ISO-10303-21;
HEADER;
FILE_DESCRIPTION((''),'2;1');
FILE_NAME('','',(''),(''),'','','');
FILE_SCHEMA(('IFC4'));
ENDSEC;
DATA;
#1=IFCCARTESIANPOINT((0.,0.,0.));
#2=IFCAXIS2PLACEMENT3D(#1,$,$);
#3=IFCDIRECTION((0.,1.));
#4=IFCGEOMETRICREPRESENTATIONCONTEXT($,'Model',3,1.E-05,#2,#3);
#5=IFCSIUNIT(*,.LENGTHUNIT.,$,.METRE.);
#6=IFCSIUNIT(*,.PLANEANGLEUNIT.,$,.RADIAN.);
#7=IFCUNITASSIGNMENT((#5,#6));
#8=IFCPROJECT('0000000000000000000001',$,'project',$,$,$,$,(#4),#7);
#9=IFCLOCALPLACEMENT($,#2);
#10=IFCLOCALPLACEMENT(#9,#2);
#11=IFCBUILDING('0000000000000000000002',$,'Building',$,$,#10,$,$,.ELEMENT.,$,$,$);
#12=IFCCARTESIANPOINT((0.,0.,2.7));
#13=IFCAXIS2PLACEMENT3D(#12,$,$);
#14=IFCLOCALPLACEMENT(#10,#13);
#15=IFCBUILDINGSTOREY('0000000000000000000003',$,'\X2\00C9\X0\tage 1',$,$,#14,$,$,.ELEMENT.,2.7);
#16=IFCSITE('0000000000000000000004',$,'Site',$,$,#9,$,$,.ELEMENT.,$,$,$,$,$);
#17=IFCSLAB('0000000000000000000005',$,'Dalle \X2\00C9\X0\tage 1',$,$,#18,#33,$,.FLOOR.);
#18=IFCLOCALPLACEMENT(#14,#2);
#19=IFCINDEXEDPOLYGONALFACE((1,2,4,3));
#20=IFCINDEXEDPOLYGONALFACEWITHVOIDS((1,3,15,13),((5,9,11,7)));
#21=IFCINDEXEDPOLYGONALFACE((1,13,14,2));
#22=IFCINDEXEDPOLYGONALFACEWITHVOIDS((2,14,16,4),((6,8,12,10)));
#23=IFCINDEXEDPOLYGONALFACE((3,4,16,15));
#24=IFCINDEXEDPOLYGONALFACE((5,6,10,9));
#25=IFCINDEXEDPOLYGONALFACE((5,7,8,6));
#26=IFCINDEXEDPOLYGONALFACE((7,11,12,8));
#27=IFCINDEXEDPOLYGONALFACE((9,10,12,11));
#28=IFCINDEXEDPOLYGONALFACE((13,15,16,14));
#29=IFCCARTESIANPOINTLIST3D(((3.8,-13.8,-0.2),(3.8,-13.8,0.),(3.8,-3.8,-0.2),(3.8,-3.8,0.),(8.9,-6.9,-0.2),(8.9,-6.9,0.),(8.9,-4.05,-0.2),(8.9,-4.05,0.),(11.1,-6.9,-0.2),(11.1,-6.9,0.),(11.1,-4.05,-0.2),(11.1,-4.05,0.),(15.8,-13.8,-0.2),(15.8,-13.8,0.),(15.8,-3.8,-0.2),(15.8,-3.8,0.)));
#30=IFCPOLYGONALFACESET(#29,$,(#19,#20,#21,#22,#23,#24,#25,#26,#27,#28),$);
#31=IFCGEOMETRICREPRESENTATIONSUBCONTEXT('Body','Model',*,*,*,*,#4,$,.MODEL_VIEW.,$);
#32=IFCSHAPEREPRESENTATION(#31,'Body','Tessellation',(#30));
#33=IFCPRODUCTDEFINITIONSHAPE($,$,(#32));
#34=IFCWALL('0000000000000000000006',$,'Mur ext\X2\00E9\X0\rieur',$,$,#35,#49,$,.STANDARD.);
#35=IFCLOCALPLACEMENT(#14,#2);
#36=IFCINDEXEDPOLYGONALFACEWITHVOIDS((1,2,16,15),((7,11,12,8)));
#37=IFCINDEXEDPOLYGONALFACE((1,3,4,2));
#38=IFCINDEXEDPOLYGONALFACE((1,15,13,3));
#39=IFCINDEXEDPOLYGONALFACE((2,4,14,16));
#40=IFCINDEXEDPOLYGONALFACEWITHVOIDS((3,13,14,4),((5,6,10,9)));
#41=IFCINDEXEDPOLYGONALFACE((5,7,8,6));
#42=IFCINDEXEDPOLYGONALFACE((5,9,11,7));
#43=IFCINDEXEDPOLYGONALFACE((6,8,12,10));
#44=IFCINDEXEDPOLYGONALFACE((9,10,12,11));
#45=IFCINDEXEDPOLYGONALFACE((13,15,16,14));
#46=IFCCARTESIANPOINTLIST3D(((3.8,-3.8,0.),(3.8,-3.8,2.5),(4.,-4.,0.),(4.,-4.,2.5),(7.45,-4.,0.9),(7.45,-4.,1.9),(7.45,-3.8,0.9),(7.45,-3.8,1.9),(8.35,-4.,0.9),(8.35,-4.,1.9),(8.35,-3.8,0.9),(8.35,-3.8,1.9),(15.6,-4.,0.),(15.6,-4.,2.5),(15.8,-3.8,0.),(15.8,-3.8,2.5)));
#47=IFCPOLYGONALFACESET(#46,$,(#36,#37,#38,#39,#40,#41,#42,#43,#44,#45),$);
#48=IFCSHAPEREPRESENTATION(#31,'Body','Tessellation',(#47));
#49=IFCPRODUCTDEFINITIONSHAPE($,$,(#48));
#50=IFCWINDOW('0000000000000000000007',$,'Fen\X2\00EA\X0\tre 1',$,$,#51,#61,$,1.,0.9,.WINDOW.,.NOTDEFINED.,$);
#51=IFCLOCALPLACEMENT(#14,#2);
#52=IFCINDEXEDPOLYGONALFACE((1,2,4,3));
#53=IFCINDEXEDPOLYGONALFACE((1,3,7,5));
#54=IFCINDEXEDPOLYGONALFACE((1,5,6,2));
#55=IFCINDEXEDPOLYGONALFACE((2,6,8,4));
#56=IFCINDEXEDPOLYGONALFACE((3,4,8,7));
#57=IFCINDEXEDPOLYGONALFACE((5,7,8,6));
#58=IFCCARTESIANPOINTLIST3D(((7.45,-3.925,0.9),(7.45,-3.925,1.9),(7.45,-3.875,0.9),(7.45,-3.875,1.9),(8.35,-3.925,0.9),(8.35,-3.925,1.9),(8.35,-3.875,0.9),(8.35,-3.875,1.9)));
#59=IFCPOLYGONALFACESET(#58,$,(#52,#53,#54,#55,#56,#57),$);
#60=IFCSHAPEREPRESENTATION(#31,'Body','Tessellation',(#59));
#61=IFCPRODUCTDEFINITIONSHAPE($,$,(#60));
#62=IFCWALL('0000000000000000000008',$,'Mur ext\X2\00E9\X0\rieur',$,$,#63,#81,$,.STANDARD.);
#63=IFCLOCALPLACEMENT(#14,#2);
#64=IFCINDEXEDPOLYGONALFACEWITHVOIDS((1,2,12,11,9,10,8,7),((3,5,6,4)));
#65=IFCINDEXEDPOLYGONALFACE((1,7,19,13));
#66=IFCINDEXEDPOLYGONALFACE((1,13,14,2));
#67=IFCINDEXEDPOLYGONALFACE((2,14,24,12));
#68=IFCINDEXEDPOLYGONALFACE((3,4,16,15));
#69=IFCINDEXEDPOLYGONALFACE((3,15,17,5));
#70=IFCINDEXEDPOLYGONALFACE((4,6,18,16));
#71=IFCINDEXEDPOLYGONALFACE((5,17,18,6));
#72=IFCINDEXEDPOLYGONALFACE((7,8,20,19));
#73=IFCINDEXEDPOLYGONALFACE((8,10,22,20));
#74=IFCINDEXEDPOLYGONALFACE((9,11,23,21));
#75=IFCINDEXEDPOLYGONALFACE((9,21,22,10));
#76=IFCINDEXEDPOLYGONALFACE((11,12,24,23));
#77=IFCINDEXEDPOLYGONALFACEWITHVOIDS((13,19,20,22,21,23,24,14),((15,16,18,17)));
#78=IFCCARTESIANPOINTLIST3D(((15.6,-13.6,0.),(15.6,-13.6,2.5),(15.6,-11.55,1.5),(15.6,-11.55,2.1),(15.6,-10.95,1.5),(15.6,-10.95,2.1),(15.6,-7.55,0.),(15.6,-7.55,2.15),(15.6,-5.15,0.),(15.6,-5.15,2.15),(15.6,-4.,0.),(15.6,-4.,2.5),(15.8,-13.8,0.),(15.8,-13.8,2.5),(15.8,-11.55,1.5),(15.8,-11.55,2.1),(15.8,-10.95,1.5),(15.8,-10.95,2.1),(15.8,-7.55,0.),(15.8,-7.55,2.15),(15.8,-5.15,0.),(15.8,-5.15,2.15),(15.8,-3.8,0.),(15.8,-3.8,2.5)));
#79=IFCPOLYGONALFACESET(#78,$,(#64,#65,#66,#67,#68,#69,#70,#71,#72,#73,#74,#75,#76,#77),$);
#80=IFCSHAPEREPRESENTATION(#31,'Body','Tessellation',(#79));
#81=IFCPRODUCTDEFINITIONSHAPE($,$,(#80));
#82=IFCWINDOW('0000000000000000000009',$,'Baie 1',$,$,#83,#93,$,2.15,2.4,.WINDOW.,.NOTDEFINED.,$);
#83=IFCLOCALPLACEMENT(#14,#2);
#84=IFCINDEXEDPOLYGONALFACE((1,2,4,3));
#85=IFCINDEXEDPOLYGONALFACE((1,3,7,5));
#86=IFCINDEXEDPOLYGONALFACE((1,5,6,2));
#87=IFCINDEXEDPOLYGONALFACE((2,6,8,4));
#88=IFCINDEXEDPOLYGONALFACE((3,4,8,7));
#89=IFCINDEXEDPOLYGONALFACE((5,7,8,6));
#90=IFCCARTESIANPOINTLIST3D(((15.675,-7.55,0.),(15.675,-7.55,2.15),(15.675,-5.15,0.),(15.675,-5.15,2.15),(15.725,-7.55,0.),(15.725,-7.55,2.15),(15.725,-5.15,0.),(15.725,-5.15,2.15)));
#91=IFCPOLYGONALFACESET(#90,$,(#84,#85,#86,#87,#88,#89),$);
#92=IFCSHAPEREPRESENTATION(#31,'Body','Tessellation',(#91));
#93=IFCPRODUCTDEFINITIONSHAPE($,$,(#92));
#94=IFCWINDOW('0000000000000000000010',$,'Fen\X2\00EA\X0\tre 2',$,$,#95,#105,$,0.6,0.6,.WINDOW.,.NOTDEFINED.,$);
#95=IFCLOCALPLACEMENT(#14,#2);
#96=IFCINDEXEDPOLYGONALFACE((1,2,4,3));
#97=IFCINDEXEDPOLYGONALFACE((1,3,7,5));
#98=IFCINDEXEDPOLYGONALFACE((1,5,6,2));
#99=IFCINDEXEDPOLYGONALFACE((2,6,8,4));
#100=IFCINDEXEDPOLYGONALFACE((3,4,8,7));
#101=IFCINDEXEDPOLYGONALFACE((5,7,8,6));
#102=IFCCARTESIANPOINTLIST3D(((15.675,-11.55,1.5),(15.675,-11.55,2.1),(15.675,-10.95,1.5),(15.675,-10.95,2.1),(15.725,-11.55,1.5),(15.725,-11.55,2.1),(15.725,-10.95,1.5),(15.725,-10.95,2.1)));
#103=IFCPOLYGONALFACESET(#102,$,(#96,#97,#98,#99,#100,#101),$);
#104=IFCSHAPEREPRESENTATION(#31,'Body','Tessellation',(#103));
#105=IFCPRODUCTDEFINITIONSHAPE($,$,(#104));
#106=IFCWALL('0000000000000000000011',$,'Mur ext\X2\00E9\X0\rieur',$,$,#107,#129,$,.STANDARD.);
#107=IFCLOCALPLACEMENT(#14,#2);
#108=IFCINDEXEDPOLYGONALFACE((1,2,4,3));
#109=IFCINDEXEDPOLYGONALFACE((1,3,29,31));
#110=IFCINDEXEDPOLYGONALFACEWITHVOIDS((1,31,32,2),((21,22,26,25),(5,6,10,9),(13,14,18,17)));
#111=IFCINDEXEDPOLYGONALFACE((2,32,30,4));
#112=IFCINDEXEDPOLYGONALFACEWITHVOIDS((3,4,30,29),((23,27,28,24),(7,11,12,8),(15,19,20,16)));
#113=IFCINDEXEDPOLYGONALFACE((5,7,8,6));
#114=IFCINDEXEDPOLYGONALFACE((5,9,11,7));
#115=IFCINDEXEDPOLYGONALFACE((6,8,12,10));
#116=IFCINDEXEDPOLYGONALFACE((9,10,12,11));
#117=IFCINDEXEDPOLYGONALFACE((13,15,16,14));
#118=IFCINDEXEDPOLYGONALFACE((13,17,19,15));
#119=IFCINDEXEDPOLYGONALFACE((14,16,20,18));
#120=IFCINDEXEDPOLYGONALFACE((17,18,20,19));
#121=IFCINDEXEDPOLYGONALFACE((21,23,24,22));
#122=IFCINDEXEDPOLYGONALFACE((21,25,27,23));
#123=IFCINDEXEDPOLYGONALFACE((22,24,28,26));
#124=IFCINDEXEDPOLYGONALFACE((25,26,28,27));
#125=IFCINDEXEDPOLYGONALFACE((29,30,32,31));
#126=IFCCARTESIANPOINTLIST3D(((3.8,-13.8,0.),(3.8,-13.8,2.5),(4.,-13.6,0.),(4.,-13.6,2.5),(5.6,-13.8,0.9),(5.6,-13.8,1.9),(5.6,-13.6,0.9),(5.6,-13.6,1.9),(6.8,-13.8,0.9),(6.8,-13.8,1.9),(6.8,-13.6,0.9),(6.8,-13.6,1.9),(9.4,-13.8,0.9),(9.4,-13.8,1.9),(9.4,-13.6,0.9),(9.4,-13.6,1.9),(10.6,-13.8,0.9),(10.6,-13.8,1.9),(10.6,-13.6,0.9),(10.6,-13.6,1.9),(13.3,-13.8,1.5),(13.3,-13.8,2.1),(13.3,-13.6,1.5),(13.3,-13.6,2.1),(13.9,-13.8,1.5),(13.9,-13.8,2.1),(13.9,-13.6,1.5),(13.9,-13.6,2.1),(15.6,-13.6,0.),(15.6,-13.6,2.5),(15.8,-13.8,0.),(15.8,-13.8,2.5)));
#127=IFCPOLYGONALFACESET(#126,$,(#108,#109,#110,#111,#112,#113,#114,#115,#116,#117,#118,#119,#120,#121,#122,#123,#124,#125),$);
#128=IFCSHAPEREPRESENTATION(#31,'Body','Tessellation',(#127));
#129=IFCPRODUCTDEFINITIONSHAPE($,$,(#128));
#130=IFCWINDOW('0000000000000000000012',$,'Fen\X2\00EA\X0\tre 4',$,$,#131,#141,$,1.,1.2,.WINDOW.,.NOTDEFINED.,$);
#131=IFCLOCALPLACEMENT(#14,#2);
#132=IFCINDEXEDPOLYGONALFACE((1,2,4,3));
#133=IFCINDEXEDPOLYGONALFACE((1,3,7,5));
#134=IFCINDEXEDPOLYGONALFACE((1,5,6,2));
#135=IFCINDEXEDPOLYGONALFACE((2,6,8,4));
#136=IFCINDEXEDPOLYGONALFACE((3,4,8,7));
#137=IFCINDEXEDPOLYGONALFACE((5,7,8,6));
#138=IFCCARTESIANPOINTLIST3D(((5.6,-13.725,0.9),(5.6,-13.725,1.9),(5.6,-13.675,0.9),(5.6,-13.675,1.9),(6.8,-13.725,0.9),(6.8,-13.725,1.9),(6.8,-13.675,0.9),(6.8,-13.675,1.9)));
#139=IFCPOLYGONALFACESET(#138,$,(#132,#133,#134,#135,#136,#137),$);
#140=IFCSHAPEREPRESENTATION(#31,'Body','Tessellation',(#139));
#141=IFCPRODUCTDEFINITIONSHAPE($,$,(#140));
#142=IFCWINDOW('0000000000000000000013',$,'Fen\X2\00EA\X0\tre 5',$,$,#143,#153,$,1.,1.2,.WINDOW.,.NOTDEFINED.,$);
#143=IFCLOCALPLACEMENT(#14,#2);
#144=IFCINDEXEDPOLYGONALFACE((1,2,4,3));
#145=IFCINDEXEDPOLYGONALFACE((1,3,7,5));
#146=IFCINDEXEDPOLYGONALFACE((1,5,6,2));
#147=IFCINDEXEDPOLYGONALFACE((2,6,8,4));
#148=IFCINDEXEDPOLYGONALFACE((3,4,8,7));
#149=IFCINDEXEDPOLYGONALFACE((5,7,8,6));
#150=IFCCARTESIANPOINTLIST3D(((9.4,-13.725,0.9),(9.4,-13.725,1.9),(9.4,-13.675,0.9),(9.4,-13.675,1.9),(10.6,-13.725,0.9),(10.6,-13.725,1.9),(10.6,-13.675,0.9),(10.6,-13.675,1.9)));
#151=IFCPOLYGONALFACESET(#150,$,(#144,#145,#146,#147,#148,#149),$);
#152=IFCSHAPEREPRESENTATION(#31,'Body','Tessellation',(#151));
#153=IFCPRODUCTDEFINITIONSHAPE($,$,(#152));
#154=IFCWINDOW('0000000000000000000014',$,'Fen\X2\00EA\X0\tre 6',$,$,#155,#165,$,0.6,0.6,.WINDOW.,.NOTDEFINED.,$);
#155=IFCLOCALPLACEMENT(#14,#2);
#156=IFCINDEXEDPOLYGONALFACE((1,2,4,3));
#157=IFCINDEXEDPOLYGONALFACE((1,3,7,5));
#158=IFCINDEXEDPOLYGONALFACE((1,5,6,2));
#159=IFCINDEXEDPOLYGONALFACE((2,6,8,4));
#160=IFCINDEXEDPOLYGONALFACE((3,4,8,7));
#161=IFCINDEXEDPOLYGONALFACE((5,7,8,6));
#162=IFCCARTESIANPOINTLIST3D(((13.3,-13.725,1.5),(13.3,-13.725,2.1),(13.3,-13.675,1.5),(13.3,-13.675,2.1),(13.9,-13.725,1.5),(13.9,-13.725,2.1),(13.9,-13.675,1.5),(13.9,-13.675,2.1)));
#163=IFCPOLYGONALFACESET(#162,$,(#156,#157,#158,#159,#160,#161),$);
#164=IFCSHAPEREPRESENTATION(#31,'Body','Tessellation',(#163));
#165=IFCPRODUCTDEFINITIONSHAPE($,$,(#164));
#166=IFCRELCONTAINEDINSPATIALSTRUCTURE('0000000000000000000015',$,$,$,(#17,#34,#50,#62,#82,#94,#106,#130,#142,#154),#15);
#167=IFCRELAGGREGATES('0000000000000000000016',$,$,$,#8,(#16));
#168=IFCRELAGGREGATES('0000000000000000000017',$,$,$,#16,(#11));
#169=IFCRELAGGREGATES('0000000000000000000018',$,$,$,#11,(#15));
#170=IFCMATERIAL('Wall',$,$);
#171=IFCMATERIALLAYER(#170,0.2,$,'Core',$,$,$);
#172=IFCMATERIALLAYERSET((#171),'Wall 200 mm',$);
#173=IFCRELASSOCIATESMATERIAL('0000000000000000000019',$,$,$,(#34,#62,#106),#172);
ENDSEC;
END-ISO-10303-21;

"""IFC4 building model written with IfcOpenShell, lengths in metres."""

from ifc_helpers import new_model, si_unit, direction, frame, origin, origin_2d, place, context, subcontext, project, spatial, polyline, rectangle, outline, extrude, material, layer, layer_set, layer_usage, element, fill, save


model = new_model("IFC4")

# Units and contexts
model_context = context("Model", 3, precision=1e-05, world=origin(), true_north=direction((0.0, 1.0)))
body_context = subcontext(model_context, "Body", "Model", "MODEL_VIEW")
ifc_project = project(units=[si_unit("LENGTHUNIT", "METRE"), si_unit("PLANEANGLEUNIT", "RADIAN")], contexts=[model_context])

# Site, building, storey
site_placement = place(None, origin())
site = spatial("IfcSite", under=ifc_project, at=site_placement, Name="Site", CompositionType="ELEMENT")
building_placement = place(site_placement, origin())
building = spatial("IfcBuilding", under=site, at=building_placement, Name="Building", CompositionType="ELEMENT")
storey_placement = place(building_placement, frame((0.0, 0.0, 2.7)))
storey = spatial("IfcBuildingStorey", under=building, at=storey_placement, Name="Étage 1", CompositionType="ELEMENT", Elevation=2.7)

# Slab
slab_placement = place(storey_placement, origin())
element("IfcSlab", 1, at=slab_placement, inside=storey, Name="Dalle Étage 1", PredefinedType="FLOOR", context=body_context, shape_type="SweptSolid", body=[
    extrude(outline(polyline([(3.8, -13.8), (15.8, -13.8), (15.8, -3.8), (3.8, -3.8), (3.8, -13.8)]), holes=[polyline([(11.1, -4.05), (11.1, -6.9), (8.9, -6.9), (8.9, -4.05), (11.1, -4.05)])]), frame((0.0, 0.0, -0.2)), (0.0, 0.0, 1.0), 0.2),
])

# Wall, opening, window
ifc_material = material(Name="Wall")
ifc_layer = layer(ifc_material, 0.2, Name="Core")
ifc_layer_set = layer_set([ifc_layer], Name="Wall 200 mm")
ifc_layer_usage = layer_usage(ifc_layer_set, "AXIS2", "POSITIVE", -0.1)
wall_1_placement = place(storey_placement, frame((3.9, -3.9, 0.0)))
wall_1 = element("IfcWall", 2, at=wall_1_placement, inside=storey, material=ifc_layer_usage, Name="Mur extérieur", PredefinedType="STANDARD", context=body_context, shape_type="SweptSolid", body=[
    extrude(outline(polyline([(0.0, 0.0), (0.1, -0.1), (11.7, -0.1), (11.8, 0.0), (11.9, 0.1), (-0.1, 0.1), (0.0, 0.0)])), origin(), (0.0, 0.0, 1.0), 2.5),
])
opening_1_placement = place(wall_1_placement, frame((4.0, 0.0, 0.9)))
opening_1 = element("IfcOpeningElement", 3, at=opening_1_placement, cuts=wall_1, PredefinedType="OPENING", context=body_context, shape_type="SweptSolid", body=[
    extrude(rectangle(XDim=0.9, YDim=0.4, at=origin_2d()), origin(), (0.0, 0.0, 1.0), 1.0),
])
window_1_placement = place(opening_1_placement, origin())
window_1 = element("IfcWindow", 4, at=window_1_placement, inside=storey, Name="Fenêtre 1", OverallHeight=1.0, OverallWidth=0.9, PartitioningType="NOTDEFINED", PredefinedType="WINDOW", context=body_context, shape_type="SweptSolid", body=[
    extrude(rectangle(XDim=0.9, YDim=0.05, at=origin_2d()), origin(), (0.0, 0.0, 1.0), 1.0),
])
fill(opening_1, window_1)

# Walls, openings, windows
wall_2_placement = place(storey_placement, frame((15.7, -3.9, 0.0), z_axis=(0.0, 0.0, 1.0), x_axis=(0.0, -1.0, 0.0)))
wall_2 = element("IfcWall", 5, at=wall_2_placement, inside=storey, material=ifc_layer_usage, Name="Mur extérieur", PredefinedType="STANDARD", context=body_context, shape_type="SweptSolid", body=[
    extrude(outline(polyline([(0.0, 0.0), (0.1, -0.1), (9.7, -0.1), (9.8, 0.0), (9.9, 0.1), (-0.1, 0.1), (0.0, 0.0)])), origin(), (0.0, 0.0, 1.0), 2.5),
])
opening_2_placement = place(wall_2_placement, frame((2.45, 0.0, 0.0)))
opening_2 = element("IfcOpeningElement", 6, at=opening_2_placement, cuts=wall_2, PredefinedType="OPENING", context=body_context, shape_type="SweptSolid", body=[
    extrude(rectangle(XDim=2.4, YDim=0.4, at=origin_2d()), origin(), (0.0, 0.0, 1.0), 2.15),
])
opening_3_placement = place(wall_2_placement, frame((7.35, 0.0, 1.5)))
opening_3 = element("IfcOpeningElement", 7, at=opening_3_placement, cuts=wall_2, PredefinedType="OPENING", context=body_context, shape_type="SweptSolid", body=[
    extrude(rectangle(XDim=0.6, YDim=0.4, at=origin_2d()), origin(), (0.0, 0.0, 1.0), 0.6),
])
window_2_placement = place(opening_2_placement, origin())
window_2 = element("IfcWindow", 8, at=window_2_placement, inside=storey, Name="Baie 1", OverallHeight=2.15, OverallWidth=2.4, PartitioningType="NOTDEFINED", PredefinedType="WINDOW", context=body_context, shape_type="SweptSolid", body=[
    extrude(rectangle(XDim=2.4, YDim=0.05, at=origin_2d()), origin(), (0.0, 0.0, 1.0), 2.15),
])
fill(opening_2, window_2)
window_3_placement = place(opening_3_placement, origin())
window_3 = element("IfcWindow", 9, at=window_3_placement, inside=storey, Name="Fenêtre 2", OverallHeight=0.6, OverallWidth=0.6, PartitioningType="NOTDEFINED", PredefinedType="WINDOW", context=body_context, shape_type="SweptSolid", body=[
    extrude(rectangle(XDim=0.6, YDim=0.05, at=origin_2d()), origin(), (0.0, 0.0, 1.0), 0.6),
])
fill(opening_3, window_3)
wall_3_placement = place(storey_placement, frame((15.7, -13.7, 0.0), z_axis=(0.0, 0.0, 1.0), x_axis=(-1.0, 0.0, 0.0)))
wall_3 = element("IfcWall", 10, at=wall_3_placement, inside=storey, material=ifc_layer_usage, Name="Mur extérieur", PredefinedType="STANDARD", context=body_context, shape_type="SweptSolid", body=[
    extrude(outline(polyline([(0.0, 0.0), (0.1, -0.1), (11.7, -0.1), (11.8, 0.0), (11.9, 0.1), (-0.1, 0.1), (0.0, 0.0)])), origin(), (0.0, 0.0, 1.0), 2.5),
])
opening_4_placement = place(wall_3_placement, frame((9.5, 0.0, 0.9), z_axis=(0.0, 0.0, 1.0), x_axis=(1.0, 0.0, 0.0)))
opening_4 = element("IfcOpeningElement", 11, at=opening_4_placement, cuts=wall_3, PredefinedType="OPENING", context=body_context, shape_type="SweptSolid", body=[
    extrude(rectangle(XDim=1.2, YDim=0.4, at=origin_2d()), origin(), (0.0, 0.0, 1.0), 1.0),
])
opening_5_placement = place(wall_3_placement, frame((5.7, 0.0, 0.9), z_axis=(0.0, 0.0, 1.0), x_axis=(1.0, 0.0, 0.0)))
opening_5 = element("IfcOpeningElement", 12, at=opening_5_placement, cuts=wall_3, PredefinedType="OPENING", context=body_context, shape_type="SweptSolid", body=[
    extrude(rectangle(XDim=1.2, YDim=0.4, at=origin_2d()), origin(), (0.0, 0.0, 1.0), 1.0),
])
opening_6_placement = place(wall_3_placement, frame((2.1, 0.0, 1.5), z_axis=(0.0, 0.0, 1.0), x_axis=(1.0, 0.0, 0.0)))
opening_6 = element("IfcOpeningElement", 13, at=opening_6_placement, cuts=wall_3, PredefinedType="OPENING", context=body_context, shape_type="SweptSolid", body=[
    extrude(rectangle(XDim=0.6, YDim=0.4, at=origin_2d()), origin(), (0.0, 0.0, 1.0), 0.6),
])
window_4_placement = place(opening_4_placement, origin())
window_4 = element("IfcWindow", 14, at=window_4_placement, inside=storey, Name="Fenêtre 4", OverallHeight=1.0, OverallWidth=1.2, PartitioningType="NOTDEFINED", PredefinedType="WINDOW", context=body_context, shape_type="SweptSolid", body=[
    extrude(rectangle(XDim=1.2, YDim=0.05, at=origin_2d()), origin(), (0.0, 0.0, 1.0), 1.0),
])
fill(opening_4, window_4)
window_5_placement = place(opening_5_placement, origin())
window_5 = element("IfcWindow", 15, at=window_5_placement, inside=storey, Name="Fenêtre 5", OverallHeight=1.0, OverallWidth=1.2, PartitioningType="NOTDEFINED", PredefinedType="WINDOW", context=body_context, shape_type="SweptSolid", body=[
    extrude(rectangle(XDim=1.2, YDim=0.05, at=origin_2d()), origin(), (0.0, 0.0, 1.0), 1.0),
])
fill(opening_5, window_5)
window_6_placement = place(opening_6_placement, origin())
window_6 = element("IfcWindow", 16, at=window_6_placement, inside=storey, Name="Fenêtre 6", OverallHeight=0.6, OverallWidth=0.6, PartitioningType="NOTDEFINED", PredefinedType="WINDOW", context=body_context, shape_type="SweptSolid", body=[
    extrude(rectangle(XDim=0.6, YDim=0.05, at=origin_2d()), origin(), (0.0, 0.0, 1.0), 0.6),
])
fill(opening_6, window_6)

save(model, "model.ifc")
